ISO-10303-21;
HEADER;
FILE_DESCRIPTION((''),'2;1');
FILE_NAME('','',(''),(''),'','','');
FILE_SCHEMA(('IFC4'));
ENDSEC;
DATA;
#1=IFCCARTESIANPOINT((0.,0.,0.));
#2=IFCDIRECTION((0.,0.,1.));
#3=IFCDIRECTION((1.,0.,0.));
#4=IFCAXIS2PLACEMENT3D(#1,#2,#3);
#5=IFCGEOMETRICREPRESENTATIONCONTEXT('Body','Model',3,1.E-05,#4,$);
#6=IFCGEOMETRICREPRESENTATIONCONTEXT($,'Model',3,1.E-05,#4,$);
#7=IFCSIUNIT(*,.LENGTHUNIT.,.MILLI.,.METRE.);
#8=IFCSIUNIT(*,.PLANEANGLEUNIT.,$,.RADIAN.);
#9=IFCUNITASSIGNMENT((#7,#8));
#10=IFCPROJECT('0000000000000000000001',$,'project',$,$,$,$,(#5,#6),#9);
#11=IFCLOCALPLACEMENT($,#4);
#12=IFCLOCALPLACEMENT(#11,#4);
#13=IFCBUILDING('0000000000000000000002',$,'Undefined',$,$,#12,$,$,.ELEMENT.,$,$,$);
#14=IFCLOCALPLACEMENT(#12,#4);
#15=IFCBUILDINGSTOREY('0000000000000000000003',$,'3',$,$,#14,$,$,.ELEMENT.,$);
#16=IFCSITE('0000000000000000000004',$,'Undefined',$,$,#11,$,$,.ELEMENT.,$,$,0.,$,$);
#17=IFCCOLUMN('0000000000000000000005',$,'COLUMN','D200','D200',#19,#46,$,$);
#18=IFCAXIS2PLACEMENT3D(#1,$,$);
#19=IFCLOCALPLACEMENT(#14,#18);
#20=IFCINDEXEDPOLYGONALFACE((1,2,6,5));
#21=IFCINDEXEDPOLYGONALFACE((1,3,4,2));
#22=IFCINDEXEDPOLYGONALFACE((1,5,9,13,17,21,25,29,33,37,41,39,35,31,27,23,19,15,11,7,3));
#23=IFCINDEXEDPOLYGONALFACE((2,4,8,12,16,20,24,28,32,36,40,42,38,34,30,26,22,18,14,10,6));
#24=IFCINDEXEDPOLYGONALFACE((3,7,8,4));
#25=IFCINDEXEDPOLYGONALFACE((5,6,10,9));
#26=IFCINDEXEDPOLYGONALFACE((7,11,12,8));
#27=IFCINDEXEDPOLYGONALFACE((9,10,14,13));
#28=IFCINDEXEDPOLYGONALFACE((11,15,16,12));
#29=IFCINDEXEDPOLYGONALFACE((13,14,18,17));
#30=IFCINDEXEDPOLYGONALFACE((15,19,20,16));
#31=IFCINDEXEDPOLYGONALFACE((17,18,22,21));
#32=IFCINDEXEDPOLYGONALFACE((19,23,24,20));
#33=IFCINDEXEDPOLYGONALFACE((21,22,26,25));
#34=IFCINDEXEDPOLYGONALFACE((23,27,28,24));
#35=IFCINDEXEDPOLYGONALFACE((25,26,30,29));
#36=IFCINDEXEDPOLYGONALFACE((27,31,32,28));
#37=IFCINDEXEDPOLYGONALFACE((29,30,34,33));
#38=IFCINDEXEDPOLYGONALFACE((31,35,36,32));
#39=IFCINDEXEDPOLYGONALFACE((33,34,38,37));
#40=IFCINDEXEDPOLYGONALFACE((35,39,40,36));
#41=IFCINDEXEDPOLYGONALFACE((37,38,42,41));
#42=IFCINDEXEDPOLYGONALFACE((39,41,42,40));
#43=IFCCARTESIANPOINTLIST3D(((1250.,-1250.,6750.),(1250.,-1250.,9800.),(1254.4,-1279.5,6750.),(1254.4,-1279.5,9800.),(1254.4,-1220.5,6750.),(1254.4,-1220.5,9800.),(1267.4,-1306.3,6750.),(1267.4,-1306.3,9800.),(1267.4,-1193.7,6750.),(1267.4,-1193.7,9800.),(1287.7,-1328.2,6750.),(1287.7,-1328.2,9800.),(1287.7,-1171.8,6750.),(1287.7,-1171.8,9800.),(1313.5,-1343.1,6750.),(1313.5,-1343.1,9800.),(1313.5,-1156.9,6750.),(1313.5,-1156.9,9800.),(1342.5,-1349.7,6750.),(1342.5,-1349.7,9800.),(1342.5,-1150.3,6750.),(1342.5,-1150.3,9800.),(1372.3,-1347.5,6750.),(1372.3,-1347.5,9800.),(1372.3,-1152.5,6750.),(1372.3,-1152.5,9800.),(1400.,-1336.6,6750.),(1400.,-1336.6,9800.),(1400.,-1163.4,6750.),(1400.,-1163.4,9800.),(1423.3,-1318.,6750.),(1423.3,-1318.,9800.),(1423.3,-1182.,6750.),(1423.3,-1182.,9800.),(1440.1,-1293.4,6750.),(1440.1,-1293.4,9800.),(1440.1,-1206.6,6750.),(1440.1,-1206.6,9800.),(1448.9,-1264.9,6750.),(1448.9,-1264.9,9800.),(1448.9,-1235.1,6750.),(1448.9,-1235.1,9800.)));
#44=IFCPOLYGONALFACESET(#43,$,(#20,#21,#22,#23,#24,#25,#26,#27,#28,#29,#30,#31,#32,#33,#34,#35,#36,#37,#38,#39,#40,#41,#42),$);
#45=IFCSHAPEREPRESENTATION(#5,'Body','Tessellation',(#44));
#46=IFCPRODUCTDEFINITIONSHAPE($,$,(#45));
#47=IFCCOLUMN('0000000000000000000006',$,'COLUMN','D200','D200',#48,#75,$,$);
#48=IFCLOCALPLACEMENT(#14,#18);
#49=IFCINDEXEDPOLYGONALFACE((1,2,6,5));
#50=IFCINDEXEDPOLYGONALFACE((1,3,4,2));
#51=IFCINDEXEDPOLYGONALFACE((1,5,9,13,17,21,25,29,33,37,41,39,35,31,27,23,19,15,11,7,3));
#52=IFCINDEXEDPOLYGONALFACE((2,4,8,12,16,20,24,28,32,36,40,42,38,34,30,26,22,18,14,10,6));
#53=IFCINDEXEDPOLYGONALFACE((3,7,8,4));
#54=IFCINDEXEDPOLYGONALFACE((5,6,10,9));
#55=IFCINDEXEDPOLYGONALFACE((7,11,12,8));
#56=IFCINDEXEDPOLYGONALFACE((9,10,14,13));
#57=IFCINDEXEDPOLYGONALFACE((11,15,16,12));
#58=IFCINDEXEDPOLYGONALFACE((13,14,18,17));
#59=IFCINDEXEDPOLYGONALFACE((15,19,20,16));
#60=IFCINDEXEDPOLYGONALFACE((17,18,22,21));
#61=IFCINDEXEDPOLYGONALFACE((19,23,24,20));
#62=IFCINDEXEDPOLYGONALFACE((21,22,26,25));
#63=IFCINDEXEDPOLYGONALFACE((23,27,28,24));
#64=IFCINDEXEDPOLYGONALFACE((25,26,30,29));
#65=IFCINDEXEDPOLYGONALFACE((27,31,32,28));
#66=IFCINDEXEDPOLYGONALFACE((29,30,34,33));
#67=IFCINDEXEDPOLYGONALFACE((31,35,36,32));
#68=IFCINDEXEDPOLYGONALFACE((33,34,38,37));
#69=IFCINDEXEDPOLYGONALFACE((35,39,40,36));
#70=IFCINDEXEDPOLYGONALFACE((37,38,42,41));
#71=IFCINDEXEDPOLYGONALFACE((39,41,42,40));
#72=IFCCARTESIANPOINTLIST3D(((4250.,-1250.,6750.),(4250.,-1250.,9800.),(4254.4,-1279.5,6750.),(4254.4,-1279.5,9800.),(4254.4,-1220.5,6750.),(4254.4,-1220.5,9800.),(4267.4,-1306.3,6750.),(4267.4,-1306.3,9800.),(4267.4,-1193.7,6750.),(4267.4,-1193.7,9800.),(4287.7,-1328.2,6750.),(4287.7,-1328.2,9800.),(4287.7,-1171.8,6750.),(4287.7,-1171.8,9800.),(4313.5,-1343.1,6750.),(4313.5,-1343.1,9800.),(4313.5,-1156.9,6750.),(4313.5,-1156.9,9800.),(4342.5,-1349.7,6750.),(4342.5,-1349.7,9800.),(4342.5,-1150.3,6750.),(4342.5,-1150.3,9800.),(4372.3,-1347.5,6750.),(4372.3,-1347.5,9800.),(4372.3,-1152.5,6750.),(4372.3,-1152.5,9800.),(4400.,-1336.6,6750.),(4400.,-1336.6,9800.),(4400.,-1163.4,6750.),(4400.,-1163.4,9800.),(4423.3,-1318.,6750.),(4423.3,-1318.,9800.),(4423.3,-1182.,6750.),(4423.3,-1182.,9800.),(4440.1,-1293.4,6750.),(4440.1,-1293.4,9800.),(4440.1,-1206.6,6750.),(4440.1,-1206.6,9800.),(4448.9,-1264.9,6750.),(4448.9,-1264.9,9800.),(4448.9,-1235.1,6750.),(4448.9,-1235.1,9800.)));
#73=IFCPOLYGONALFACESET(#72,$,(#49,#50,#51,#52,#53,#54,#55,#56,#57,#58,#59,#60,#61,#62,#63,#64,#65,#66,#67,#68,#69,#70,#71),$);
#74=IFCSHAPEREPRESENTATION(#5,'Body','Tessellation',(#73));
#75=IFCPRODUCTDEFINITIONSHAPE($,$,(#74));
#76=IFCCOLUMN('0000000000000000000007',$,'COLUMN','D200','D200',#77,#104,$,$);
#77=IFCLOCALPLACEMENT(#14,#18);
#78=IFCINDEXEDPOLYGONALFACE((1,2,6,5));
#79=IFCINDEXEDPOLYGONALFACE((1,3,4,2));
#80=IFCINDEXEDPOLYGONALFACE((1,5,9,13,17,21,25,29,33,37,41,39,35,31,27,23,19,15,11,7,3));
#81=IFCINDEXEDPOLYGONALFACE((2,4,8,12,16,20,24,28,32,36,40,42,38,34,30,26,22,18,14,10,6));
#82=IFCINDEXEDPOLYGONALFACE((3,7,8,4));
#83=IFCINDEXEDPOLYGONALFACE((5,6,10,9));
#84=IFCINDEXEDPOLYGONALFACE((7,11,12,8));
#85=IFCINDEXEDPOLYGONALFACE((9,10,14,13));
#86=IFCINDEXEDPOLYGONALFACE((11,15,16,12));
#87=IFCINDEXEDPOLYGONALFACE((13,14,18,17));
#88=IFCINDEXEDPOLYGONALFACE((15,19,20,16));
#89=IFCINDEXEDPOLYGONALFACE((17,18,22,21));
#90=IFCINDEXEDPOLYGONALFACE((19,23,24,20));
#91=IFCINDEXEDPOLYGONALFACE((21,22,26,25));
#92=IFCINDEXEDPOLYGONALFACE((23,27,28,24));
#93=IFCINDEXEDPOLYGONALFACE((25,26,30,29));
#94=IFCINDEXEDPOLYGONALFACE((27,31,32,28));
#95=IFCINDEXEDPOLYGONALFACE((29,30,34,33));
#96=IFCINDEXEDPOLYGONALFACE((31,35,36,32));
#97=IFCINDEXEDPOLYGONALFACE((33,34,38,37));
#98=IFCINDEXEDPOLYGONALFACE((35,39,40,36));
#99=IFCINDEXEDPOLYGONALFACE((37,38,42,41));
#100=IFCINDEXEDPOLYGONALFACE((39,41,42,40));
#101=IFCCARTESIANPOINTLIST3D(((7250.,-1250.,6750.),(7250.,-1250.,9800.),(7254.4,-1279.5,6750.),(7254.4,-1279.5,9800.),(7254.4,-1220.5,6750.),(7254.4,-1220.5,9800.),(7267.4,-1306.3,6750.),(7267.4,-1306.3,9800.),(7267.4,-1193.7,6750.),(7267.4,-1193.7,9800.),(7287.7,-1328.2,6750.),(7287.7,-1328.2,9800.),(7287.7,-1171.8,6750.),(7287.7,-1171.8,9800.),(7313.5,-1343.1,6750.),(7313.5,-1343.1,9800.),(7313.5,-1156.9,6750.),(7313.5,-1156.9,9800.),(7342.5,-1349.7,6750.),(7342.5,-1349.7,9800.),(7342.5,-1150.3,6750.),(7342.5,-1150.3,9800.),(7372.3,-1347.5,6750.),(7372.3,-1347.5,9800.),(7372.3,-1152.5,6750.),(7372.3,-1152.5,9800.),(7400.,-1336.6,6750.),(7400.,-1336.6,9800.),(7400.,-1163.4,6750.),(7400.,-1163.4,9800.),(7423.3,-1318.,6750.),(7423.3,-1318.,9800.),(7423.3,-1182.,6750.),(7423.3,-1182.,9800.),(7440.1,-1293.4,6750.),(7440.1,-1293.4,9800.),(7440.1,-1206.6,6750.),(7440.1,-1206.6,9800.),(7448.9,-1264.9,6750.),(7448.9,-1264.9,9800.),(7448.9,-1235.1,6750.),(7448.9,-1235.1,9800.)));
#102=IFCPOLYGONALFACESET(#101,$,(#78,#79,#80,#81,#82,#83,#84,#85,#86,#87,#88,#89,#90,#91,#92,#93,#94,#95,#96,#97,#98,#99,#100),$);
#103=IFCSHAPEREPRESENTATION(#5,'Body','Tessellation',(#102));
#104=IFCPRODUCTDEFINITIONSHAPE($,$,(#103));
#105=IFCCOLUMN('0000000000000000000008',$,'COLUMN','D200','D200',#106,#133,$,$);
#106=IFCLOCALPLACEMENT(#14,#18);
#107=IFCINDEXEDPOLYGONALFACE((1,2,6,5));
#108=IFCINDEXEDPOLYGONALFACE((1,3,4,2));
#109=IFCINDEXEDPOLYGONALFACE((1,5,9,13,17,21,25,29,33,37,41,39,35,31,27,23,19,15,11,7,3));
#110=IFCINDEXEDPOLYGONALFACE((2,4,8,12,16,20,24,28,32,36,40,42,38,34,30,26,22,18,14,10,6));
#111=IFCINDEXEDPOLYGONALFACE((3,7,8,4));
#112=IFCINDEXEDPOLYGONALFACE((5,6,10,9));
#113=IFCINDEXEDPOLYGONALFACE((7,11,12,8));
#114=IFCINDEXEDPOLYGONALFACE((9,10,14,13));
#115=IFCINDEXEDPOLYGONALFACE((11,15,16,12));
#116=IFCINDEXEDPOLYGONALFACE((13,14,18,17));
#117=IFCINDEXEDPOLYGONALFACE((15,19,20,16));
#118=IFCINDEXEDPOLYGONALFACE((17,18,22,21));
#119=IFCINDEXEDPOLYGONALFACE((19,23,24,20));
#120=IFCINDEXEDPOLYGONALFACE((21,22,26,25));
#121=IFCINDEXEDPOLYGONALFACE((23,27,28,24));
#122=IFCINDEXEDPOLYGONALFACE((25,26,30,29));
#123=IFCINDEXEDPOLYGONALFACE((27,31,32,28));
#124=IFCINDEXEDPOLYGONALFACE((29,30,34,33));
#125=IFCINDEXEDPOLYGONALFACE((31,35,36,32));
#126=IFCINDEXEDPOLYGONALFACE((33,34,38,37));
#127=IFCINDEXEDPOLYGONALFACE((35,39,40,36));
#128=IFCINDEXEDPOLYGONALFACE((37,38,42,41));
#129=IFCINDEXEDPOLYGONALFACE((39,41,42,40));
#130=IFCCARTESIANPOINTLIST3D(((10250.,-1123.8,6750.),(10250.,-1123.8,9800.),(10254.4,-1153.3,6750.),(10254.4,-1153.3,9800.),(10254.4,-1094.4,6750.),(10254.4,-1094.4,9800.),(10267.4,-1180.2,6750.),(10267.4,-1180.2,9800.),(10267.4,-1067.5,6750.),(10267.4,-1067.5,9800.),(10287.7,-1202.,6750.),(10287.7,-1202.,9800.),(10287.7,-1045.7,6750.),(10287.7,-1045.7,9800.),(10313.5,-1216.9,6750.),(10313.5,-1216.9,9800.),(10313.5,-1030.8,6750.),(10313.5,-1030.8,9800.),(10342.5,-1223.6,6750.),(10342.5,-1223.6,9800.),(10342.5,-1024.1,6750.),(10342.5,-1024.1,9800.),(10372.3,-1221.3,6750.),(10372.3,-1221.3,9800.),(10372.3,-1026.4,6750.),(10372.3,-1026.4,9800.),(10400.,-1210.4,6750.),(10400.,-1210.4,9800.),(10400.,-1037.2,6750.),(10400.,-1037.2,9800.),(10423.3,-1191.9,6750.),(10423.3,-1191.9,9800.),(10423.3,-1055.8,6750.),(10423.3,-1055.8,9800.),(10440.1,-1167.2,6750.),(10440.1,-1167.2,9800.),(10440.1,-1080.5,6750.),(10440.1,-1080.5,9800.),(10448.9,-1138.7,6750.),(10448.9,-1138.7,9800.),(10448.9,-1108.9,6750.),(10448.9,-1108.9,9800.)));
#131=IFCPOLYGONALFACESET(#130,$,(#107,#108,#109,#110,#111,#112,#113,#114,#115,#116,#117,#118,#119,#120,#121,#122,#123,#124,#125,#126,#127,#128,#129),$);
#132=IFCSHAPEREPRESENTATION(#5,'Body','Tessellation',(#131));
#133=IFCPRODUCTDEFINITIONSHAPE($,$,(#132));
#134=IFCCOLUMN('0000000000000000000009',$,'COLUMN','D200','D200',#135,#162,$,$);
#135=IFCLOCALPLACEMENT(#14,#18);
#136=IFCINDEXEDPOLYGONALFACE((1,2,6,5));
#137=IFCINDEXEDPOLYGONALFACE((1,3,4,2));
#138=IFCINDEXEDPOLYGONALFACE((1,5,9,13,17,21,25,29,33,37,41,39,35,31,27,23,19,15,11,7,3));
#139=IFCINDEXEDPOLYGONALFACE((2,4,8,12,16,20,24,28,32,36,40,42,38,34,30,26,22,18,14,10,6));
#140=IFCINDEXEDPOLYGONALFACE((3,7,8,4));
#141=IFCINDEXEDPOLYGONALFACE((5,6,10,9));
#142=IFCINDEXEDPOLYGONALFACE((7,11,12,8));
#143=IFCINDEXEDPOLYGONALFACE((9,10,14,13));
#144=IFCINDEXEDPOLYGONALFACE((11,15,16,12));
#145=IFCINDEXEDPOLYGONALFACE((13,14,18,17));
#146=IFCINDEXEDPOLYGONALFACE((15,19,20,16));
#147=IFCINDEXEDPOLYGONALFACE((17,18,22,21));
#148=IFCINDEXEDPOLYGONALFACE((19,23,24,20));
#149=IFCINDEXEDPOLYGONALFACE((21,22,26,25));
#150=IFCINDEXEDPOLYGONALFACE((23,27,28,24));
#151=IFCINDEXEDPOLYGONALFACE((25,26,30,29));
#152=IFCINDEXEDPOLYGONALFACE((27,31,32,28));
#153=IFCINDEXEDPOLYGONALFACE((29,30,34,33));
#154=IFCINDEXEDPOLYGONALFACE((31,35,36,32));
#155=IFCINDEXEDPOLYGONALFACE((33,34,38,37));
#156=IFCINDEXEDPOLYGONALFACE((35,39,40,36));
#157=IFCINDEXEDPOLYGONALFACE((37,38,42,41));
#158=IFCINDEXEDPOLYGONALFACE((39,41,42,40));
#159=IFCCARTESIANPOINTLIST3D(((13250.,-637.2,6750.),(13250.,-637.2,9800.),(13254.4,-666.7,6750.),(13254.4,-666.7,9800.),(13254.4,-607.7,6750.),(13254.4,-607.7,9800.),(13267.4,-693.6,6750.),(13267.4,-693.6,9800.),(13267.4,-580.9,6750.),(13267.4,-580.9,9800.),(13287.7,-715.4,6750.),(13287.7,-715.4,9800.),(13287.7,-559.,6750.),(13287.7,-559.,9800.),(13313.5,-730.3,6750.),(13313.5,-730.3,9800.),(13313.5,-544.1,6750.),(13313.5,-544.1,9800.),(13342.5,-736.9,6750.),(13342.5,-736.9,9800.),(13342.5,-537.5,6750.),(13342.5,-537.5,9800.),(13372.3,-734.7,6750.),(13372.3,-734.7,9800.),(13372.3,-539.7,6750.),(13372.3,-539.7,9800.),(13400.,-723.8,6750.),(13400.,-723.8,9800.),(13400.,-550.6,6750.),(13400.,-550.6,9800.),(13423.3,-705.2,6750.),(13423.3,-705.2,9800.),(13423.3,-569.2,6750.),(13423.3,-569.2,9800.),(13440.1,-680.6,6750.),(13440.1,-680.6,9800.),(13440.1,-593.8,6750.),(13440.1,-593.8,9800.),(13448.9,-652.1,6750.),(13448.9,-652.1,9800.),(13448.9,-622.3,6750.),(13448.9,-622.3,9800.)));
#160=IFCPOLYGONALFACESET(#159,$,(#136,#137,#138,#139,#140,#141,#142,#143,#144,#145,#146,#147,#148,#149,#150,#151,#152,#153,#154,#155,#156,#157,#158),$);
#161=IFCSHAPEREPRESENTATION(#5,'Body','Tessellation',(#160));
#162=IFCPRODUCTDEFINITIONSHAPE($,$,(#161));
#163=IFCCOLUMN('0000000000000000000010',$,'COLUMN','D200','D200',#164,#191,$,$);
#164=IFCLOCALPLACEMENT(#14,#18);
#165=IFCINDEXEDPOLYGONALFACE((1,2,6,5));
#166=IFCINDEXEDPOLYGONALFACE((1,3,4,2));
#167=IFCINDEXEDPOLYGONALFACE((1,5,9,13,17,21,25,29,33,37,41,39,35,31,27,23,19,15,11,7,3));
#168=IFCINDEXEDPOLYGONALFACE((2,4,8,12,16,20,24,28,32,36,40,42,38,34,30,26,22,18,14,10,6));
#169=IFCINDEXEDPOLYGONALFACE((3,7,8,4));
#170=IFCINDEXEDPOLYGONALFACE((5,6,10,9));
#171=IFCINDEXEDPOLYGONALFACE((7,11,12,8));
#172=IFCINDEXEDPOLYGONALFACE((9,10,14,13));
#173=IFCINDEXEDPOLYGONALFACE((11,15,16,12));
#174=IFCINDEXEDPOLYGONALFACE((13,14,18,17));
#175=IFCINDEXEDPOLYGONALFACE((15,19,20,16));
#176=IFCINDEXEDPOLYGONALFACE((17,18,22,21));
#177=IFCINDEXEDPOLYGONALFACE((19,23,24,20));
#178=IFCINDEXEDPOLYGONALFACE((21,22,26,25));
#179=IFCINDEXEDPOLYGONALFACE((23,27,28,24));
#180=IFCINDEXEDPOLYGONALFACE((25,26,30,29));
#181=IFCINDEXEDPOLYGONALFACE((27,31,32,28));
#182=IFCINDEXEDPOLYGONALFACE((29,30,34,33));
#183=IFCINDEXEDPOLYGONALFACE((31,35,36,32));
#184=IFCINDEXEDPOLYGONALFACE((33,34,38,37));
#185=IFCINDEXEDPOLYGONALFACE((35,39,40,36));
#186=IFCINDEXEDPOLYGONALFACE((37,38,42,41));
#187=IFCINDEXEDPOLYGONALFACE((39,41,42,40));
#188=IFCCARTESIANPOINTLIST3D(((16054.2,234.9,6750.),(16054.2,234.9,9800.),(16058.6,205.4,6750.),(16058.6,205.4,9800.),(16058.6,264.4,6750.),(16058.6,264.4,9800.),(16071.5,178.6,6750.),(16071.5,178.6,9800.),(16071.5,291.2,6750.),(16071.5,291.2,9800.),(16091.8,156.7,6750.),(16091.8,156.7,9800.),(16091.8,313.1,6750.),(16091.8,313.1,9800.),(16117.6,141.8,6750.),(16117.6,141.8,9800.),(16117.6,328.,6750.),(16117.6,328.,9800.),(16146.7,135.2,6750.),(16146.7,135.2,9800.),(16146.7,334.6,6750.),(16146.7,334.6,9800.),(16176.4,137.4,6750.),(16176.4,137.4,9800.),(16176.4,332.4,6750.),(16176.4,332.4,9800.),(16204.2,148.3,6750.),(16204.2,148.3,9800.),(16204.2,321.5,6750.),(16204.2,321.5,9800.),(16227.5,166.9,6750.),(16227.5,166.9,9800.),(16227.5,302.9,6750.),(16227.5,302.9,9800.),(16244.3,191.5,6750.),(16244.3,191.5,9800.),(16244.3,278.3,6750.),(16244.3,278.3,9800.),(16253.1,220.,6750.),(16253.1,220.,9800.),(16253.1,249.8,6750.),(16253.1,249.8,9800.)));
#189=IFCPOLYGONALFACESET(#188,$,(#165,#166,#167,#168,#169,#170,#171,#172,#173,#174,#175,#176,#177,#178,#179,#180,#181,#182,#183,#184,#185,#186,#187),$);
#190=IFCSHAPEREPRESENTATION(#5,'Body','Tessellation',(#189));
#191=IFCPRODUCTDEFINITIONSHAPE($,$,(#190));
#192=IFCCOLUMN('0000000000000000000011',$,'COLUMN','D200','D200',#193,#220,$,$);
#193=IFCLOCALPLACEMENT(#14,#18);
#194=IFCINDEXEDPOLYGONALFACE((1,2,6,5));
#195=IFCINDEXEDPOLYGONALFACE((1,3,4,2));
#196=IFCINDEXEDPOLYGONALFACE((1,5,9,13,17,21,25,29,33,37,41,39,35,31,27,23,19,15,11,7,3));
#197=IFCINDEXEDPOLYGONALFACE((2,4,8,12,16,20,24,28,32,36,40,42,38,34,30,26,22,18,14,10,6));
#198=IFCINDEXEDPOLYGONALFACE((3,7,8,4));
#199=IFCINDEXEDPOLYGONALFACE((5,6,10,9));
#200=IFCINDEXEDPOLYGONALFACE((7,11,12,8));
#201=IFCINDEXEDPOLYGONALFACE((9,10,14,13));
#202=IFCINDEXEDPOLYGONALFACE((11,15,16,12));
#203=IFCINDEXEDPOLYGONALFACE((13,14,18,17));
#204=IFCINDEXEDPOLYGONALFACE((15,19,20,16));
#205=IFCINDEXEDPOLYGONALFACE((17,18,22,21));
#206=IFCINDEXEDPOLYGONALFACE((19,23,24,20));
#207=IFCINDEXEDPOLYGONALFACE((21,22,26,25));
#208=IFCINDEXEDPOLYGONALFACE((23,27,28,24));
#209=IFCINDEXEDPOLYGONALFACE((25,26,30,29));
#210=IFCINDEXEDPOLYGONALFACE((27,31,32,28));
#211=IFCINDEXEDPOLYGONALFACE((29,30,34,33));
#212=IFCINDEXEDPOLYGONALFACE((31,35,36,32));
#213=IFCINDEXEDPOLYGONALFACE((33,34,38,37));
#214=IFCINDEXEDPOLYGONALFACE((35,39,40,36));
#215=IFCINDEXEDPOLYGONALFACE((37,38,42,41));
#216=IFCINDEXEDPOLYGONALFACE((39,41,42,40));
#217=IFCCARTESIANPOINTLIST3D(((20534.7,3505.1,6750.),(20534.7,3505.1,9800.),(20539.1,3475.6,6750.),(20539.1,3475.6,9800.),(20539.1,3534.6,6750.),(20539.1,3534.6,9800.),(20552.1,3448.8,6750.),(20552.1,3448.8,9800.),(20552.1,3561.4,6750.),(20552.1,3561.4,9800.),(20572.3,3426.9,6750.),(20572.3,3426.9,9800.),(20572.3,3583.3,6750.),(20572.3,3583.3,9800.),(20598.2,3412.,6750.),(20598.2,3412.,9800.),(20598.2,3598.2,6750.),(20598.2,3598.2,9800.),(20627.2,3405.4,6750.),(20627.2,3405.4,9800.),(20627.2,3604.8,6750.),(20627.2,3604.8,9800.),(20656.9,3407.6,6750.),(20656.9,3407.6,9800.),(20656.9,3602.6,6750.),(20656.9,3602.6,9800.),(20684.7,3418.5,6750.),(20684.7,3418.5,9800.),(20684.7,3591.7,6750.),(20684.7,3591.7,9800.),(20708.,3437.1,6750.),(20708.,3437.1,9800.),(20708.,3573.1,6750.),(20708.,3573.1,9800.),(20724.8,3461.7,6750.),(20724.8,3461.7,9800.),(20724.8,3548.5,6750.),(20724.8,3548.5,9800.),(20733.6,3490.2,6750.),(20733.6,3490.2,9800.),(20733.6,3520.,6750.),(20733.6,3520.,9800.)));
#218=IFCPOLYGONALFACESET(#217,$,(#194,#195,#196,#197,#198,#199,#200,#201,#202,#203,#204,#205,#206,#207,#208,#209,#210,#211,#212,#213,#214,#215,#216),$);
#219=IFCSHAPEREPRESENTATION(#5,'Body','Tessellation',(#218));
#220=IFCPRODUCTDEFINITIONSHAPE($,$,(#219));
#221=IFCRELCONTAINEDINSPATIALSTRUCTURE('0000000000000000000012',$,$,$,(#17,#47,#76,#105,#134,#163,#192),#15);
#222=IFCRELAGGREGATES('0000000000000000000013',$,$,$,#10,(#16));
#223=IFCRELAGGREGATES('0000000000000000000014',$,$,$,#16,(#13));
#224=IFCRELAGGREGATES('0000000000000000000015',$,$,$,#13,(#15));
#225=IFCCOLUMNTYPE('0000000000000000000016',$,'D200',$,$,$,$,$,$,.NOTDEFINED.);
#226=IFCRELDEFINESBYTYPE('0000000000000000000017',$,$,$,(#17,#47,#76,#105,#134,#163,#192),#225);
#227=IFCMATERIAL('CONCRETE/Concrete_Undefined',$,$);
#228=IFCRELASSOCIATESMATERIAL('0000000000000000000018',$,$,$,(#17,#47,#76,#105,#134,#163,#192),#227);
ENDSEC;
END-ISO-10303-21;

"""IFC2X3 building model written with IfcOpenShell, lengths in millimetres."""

from ifc_helpers import new_model, si_unit, frame, origin_with_axes, origin_2d_with_axis, place, context, project, spatial, circle, extrude, material, type_object, element, save


model = new_model("IFC2X3")

# Units and contexts
model_context_1 = context("Model", 3, precision=1e-05, world=origin_with_axes(), identifier="Body")
model_context_2 = context("Model", 3, precision=1e-05, world=origin_with_axes())
ifc_project = project(units=[si_unit("LENGTHUNIT", "METRE", prefix="MILLI"), si_unit("PLANEANGLEUNIT", "RADIAN")], contexts=[model_context_1, model_context_2])

# Site, building, storey
site_placement = place(None, origin_with_axes())
site = spatial("IfcSite", under=ifc_project, at=site_placement, Name="Undefined", CompositionType="ELEMENT", RefElevation=0.0)
building_placement = place(site_placement, origin_with_axes())
building = spatial("IfcBuilding", under=site, at=building_placement, Name="Undefined", CompositionType="ELEMENT")
storey_placement = place(building_placement, origin_with_axes())
storey = spatial("IfcBuildingStorey", under=building, at=storey_placement, Name="3", CompositionType="ELEMENT")

# Columns
ifc_material = material(Name="CONCRETE/Concrete_Undefined")
column_type = type_object("IfcColumnType", Name="D200", PredefinedType="NOTDEFINED")
for number, where, z_axis, x_axis, name in (
    (1, (1350.0, -1250.0, 6750.0), (0.0, 0.0, 1.0), (1.0, 0.0, 0.0), "COLUMN"),
    (2, (4350.0, -1250.0, 6750.0), (0.0, 0.0, 1.0), (1.0, 0.0, 0.0), "COLUMN"),
    (3, (7350.0, -1250.0, 6750.0), (0.0, 0.0, 1.0), (1.0, 0.0, 0.0), "COLUMN"),
    (4, (10350.0, -1123.8, 6750.0), (0.0, 0.0, 1.0), (1.0, 0.0, 0.0), "COLUMN"),
    (5, (13350.0, -637.2, 6750.0), (0.0, 0.0, 1.0), (1.0, 0.0, 0.0), "COLUMN"),
    (6, (16154.2, 234.9, 6750.0), (0.0, 0.0, 1.0), (1.0, 0.0, 0.0), "COLUMN"),
    (7, (20634.7, 3505.1, 6750.0), (0.0, 0.0, 1.0), (1.0, 0.0, 0.0), "COLUMN"),
):
    element("IfcColumn", number, at=place(storey_placement, frame(where, z_axis=z_axis, x_axis=x_axis)), inside=storey, type_object=column_type, material=ifc_material, Name=name, Description="D200", ObjectType="D200", context=model_context_1, shape_type="SweptSolid", body=[
        extrude(circle(Radius=100.0, at=origin_2d_with_axis()), frame((0.0, 0.0, 3050.0), z_axis=(0.0, 0.0, -1.0), x_axis=(-1.0, 0.0, 0.0)), (0.0, 0.0, 1.0), 3050.0),
    ])

save(model, "model.ifc")
